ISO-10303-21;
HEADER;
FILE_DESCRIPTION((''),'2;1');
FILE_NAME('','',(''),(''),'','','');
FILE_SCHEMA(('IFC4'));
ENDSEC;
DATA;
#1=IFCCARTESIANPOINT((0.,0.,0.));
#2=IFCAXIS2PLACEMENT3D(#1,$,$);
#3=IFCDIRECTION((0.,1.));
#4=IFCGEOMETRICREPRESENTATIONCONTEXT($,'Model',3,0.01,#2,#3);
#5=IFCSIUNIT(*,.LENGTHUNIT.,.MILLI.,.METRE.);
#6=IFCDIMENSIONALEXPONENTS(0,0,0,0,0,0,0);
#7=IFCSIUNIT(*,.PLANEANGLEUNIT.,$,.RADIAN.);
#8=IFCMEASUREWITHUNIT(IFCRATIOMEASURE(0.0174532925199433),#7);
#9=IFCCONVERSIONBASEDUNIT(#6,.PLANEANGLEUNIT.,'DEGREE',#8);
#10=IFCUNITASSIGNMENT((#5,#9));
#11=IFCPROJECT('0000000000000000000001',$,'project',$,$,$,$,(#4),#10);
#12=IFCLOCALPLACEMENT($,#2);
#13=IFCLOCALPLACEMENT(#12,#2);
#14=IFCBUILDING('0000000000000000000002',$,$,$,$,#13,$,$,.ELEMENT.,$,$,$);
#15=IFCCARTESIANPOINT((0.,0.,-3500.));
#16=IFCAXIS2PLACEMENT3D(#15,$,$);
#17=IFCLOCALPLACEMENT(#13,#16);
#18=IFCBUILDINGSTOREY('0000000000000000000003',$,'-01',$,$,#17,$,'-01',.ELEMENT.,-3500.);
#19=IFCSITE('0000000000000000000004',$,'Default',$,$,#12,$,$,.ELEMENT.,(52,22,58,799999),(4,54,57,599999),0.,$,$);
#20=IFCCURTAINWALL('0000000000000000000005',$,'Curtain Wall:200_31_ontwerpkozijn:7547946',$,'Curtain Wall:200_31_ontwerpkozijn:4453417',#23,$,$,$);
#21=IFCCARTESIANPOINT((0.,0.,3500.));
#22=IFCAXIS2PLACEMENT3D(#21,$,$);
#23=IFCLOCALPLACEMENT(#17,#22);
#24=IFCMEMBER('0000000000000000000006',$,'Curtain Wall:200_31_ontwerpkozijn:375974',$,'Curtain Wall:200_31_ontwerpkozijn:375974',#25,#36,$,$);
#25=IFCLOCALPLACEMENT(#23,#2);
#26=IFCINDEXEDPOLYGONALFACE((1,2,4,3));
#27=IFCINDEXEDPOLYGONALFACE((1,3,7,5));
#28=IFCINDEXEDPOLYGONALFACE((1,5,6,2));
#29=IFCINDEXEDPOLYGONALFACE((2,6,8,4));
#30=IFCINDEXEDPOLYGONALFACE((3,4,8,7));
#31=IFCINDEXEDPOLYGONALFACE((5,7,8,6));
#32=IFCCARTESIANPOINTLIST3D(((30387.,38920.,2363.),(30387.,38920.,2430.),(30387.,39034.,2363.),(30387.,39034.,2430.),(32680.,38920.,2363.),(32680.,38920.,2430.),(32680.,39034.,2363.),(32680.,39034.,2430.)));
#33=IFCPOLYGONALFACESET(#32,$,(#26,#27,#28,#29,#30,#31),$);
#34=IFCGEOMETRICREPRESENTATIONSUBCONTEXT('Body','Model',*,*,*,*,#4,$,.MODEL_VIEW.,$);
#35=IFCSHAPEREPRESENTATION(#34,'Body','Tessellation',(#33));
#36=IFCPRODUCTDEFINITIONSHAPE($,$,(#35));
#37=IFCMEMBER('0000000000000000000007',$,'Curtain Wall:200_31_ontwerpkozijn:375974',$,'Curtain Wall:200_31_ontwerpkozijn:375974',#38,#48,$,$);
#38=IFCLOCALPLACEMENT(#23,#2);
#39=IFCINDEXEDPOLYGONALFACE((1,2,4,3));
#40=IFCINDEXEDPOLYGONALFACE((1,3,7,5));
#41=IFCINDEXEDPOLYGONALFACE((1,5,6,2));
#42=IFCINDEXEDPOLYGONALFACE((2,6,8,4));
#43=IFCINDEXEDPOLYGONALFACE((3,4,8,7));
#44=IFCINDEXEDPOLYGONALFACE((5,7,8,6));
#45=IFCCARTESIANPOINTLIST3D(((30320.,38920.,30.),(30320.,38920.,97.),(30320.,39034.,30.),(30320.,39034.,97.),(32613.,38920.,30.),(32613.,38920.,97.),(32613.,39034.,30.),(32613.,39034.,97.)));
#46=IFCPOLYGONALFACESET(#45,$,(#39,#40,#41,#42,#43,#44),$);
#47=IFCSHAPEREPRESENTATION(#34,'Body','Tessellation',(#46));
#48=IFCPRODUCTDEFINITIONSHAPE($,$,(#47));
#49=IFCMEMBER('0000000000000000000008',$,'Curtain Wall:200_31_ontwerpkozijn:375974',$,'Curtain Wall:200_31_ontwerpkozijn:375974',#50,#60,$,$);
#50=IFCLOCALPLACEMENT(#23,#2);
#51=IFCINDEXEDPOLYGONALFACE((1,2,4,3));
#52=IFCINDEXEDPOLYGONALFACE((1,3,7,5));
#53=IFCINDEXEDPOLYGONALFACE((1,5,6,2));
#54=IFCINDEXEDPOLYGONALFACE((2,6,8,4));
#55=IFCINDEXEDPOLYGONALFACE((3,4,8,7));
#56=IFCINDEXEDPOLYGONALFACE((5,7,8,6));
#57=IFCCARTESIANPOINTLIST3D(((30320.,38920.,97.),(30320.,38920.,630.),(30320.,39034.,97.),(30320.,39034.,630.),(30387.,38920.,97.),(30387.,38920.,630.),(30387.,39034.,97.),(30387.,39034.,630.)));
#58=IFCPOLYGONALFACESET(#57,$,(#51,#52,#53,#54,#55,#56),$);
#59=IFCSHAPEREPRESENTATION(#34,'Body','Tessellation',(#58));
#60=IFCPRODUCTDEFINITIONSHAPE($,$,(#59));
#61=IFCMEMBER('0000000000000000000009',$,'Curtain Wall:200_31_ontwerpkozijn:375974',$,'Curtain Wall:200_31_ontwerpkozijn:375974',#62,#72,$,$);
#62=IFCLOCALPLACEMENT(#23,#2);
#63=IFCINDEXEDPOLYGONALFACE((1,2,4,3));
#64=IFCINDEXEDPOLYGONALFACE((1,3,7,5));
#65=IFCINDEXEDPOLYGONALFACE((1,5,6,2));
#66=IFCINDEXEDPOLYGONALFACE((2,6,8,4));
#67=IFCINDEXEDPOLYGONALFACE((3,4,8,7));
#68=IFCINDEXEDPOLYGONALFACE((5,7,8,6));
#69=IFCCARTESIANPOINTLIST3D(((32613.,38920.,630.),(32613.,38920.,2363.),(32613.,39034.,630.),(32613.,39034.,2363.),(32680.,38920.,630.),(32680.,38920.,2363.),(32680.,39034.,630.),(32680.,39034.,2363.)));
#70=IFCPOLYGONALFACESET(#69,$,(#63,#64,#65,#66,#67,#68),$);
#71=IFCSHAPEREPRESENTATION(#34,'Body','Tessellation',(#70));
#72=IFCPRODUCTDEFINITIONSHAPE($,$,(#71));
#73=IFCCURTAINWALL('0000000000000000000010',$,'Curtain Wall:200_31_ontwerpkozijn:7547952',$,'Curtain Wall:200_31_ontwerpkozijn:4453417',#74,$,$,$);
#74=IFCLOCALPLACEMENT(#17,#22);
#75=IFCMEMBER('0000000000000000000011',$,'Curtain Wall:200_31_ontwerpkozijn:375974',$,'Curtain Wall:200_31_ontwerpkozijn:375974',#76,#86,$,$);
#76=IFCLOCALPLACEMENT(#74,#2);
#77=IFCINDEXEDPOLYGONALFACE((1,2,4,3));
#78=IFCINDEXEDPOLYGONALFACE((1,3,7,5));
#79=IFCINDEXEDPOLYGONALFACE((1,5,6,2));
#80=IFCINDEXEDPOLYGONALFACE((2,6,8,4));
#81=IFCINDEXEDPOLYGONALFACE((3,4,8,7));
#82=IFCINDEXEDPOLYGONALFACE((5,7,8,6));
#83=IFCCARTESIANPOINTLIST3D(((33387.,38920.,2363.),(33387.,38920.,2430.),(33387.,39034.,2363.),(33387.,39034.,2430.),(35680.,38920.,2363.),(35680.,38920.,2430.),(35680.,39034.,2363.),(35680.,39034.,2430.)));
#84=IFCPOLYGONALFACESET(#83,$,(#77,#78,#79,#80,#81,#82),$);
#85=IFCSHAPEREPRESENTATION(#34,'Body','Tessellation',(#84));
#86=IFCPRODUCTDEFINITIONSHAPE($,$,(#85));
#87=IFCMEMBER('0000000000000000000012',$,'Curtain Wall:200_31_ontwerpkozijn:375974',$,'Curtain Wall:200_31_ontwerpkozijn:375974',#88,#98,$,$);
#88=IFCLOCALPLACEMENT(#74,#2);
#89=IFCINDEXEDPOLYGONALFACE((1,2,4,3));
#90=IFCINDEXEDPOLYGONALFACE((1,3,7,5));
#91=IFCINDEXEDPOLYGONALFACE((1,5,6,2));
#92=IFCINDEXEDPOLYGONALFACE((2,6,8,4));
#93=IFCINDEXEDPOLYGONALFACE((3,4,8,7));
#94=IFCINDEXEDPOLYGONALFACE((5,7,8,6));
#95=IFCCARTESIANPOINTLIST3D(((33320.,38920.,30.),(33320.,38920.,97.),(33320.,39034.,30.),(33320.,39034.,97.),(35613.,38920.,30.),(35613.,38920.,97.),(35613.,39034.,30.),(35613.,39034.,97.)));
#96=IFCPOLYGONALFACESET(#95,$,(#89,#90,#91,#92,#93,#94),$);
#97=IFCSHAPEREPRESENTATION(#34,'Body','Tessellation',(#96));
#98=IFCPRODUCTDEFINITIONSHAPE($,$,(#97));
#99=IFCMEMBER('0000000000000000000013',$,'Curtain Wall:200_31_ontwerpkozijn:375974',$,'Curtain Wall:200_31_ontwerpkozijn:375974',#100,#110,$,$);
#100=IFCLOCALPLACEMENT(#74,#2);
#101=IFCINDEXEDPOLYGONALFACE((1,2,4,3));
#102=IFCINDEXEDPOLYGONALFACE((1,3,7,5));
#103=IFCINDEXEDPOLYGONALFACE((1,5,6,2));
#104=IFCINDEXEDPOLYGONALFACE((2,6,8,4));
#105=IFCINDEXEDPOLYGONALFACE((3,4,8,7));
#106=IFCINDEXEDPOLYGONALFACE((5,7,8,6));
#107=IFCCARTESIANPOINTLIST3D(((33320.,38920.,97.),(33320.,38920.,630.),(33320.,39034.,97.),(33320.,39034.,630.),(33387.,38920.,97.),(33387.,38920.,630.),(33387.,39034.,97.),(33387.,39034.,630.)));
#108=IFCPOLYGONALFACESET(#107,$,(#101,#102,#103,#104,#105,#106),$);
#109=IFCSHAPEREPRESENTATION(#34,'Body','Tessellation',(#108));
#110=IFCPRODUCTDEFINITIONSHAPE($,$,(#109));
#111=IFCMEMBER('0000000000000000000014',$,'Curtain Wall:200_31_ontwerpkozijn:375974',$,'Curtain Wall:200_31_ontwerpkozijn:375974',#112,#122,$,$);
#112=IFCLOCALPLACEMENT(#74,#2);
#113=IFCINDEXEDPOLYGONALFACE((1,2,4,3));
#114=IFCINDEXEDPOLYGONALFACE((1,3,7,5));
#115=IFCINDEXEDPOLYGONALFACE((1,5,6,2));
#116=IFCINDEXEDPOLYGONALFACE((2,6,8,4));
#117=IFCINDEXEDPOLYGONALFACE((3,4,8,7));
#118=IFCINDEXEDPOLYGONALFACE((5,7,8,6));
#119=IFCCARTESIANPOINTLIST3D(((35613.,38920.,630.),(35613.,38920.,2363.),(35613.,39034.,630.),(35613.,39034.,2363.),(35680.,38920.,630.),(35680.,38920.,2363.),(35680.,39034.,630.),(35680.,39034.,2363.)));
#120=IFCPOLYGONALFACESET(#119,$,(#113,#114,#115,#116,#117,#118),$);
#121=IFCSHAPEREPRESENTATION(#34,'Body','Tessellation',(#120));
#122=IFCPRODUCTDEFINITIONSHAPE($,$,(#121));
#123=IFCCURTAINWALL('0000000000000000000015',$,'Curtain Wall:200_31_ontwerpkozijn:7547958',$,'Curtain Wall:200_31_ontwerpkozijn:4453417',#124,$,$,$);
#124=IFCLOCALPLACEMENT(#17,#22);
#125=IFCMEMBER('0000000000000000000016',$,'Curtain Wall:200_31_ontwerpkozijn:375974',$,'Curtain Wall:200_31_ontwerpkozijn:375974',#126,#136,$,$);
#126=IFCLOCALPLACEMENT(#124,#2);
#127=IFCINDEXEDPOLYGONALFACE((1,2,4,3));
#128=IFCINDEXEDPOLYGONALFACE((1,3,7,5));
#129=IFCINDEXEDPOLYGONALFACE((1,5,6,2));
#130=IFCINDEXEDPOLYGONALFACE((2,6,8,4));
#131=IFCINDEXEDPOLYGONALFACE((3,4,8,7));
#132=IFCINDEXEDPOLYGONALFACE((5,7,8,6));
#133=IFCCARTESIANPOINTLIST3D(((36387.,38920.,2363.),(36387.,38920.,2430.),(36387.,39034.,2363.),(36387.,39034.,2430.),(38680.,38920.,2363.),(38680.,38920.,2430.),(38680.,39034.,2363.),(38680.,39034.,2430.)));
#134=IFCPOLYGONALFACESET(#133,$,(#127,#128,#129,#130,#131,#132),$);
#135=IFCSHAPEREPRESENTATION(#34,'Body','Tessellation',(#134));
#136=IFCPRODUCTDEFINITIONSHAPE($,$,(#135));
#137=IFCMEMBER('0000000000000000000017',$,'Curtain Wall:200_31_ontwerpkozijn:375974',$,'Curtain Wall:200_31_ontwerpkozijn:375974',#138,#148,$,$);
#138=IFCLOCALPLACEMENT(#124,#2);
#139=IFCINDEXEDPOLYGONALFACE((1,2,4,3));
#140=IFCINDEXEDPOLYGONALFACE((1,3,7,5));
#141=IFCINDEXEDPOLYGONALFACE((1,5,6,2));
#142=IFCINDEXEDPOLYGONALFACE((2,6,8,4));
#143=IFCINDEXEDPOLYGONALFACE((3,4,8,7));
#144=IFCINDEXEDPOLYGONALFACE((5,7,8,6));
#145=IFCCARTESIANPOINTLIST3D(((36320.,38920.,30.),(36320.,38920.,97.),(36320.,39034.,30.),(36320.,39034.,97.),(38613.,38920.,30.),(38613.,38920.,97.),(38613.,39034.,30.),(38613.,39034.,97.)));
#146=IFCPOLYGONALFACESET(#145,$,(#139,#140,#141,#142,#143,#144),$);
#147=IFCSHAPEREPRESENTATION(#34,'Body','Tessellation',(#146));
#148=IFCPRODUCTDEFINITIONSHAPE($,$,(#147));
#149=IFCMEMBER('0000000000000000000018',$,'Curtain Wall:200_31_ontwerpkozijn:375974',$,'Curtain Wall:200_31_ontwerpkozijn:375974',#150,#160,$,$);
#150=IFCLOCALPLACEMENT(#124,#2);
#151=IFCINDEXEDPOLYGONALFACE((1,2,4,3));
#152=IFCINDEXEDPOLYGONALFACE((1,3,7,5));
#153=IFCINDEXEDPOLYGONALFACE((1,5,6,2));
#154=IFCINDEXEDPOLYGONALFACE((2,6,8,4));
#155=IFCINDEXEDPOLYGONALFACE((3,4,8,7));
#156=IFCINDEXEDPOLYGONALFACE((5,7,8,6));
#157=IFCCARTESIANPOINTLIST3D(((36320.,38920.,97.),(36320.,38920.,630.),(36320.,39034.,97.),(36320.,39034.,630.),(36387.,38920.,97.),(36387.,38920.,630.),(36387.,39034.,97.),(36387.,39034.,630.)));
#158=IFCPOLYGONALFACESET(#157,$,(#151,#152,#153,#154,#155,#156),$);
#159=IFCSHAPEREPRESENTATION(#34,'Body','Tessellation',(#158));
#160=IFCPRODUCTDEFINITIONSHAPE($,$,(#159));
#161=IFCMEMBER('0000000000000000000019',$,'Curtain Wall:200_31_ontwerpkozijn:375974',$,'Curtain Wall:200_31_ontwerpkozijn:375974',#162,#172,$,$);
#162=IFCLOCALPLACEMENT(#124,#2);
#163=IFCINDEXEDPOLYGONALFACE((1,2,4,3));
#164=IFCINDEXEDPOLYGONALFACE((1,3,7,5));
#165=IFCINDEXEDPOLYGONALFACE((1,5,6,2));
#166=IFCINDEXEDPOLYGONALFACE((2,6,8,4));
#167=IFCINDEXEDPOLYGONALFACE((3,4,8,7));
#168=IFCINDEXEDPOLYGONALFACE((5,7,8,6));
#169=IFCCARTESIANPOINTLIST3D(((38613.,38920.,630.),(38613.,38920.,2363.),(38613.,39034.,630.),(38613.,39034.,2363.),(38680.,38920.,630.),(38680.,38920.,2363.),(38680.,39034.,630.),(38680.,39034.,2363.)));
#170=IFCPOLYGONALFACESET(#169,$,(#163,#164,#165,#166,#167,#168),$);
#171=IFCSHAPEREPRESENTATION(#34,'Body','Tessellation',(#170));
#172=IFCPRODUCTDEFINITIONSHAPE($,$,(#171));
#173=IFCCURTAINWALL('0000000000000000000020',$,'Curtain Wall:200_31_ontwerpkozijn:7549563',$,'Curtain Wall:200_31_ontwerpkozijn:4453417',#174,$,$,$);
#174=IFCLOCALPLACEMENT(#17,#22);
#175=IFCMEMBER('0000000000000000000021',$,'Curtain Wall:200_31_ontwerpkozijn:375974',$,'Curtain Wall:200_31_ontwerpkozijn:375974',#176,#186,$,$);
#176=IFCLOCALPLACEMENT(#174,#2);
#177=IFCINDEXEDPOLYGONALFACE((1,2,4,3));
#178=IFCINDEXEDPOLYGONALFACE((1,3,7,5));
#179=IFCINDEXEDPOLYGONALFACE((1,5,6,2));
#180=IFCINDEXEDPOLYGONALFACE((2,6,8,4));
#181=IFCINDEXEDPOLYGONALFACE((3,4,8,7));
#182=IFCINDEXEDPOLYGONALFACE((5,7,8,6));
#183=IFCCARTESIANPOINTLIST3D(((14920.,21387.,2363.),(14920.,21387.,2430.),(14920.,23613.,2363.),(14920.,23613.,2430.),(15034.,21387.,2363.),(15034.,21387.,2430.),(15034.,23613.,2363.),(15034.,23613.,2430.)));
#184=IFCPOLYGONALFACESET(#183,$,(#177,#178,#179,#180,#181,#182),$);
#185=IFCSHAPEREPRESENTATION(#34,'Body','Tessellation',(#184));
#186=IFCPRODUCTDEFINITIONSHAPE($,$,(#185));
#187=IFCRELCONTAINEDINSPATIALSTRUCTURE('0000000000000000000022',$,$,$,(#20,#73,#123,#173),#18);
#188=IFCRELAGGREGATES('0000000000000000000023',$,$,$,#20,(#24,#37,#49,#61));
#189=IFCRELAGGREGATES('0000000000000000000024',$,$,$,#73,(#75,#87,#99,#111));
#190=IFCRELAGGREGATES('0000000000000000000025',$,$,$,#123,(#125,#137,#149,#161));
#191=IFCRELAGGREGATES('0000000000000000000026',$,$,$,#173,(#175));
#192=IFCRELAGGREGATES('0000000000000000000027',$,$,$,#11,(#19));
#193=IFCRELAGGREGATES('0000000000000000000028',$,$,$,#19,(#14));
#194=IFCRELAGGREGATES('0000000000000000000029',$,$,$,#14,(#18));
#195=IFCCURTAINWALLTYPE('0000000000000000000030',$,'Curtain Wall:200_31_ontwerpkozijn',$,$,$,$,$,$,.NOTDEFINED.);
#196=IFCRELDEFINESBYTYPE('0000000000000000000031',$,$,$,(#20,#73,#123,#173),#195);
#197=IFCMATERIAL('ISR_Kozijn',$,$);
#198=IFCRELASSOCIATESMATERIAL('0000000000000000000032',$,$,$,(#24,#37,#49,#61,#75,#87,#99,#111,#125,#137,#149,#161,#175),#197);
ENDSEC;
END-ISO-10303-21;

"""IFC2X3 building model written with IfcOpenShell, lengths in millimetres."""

from ifc_helpers import new_model, entity, si_unit, converted_unit, direction, frame, frame_2d, origin, origin_2d_with_axis, place, context, subcontext, project, spatial, rectangle, extrude, material, type_object, element, aggregate, save


model = new_model("IFC2X3")

# Units and contexts
model_context = context("Model", 3, precision=0.01, world=origin(), true_north=direction((0.0, 1.0)))
body_context = subcontext(model_context, "Body", "Model", "MODEL_VIEW")
ifc_project = project(units=[si_unit("LENGTHUNIT", "METRE", prefix="MILLI"), converted_unit("PLANEANGLEUNIT", "DEGREE", entity("IfcRatioMeasure", 0.0174532925199433), si_unit("PLANEANGLEUNIT", "RADIAN"), dimensions=[0, 0, 0, 0, 0, 0, 0])], contexts=[model_context])

# Site, building, storey
site_placement = place(None, origin())
site = spatial("IfcSite", under=ifc_project, at=site_placement, Name="Default", CompositionType="ELEMENT", RefLatitude=(52, 22, 58, 799999), RefLongitude=(4, 54, 57, 599999), RefElevation=0.0)
building_placement = place(site_placement, origin())
building = spatial("IfcBuilding", under=site, at=building_placement, CompositionType="ELEMENT")
storey_placement = place(building_placement, frame((0.0, 0.0, -3500.0)))
storey = spatial("IfcBuildingStorey", under=building, at=storey_placement, Name="-01", LongName="-01", CompositionType="ELEMENT", Elevation=-3500.0)

# Curtain walls, members
curtain_wall_type = type_object("IfcCurtainWallType", Name="Curtain Wall:200_31_ontwerpkozijn", PredefinedType="NOTDEFINED")
ifc_material = material(Name="ISR_Kozijn")
curtain_wall_1_placement = place(storey_placement, frame((0.0, 0.0, 3500.0)))
curtain_wall_1 = element("IfcCurtainWall", 1, at=curtain_wall_1_placement, inside=storey, type_object=curtain_wall_type, Name="Curtain Wall:200_31_ontwerpkozijn:7547946", ObjectType="Curtain Wall:200_31_ontwerpkozijn:4453417")
member_1_placement = place(curtain_wall_1_placement, origin())
member_1 = element("IfcMember", 2, at=member_1_placement, material=ifc_material, Name="Curtain Wall:200_31_ontwerpkozijn:375974", ObjectType="Curtain Wall:200_31_ontwerpkozijn:375974", context=body_context, shape_type="SweptSolid", body=[
    extrude(rectangle(XDim=67.0, YDim=114.0, at=frame_2d((0.0, 0.0), x_axis=(1.0, 0.0))), frame((30387.0, 38977.0, 2396.5), z_axis=(1.0, 0.0, 0.0), x_axis=(0.0, 0.0, -1.0)), (0.0, 0.0, 1.0), 2293.0),
])
member_2_placement = place(curtain_wall_1_placement, origin())
member_2 = element("IfcMember", 3, at=member_2_placement, material=ifc_material, Name="Curtain Wall:200_31_ontwerpkozijn:375974", ObjectType="Curtain Wall:200_31_ontwerpkozijn:375974", context=body_context, shape_type="SweptSolid", body=[
    extrude(rectangle(XDim=67.0, YDim=114.0, at=frame_2d((0.0, 0.0), x_axis=(1.0, 0.0))), frame((32613.0, 38977.0, 63.5), z_axis=(-1.0, 0.0, 0.0), x_axis=(0.0, 0.0, -1.0)), (0.0, 0.0, 1.0), 2293.0),
])
member_3_placement = place(curtain_wall_1_placement, origin())
member_3 = element("IfcMember", 4, at=member_3_placement, material=ifc_material, Name="Curtain Wall:200_31_ontwerpkozijn:375974", ObjectType="Curtain Wall:200_31_ontwerpkozijn:375974", context=body_context, shape_type="SweptSolid", body=[
    extrude(rectangle(XDim=67.0, YDim=114.0, at=frame_2d((0.0, 0.0), x_axis=(1.0, 0.0))), frame((30353.5, 38977.0, 97.0), z_axis=(0.0, 0.0, 1.0), x_axis=(-1.0, 0.0, 0.0)), (0.0, 0.0, 1.0), 533.0),
])
member_4_placement = place(curtain_wall_1_placement, origin())
member_4 = element("IfcMember", 5, at=member_4_placement, material=ifc_material, Name="Curtain Wall:200_31_ontwerpkozijn:375974", ObjectType="Curtain Wall:200_31_ontwerpkozijn:375974", context=body_context, shape_type="SweptSolid", body=[
    extrude(rectangle(XDim=67.0, YDim=114.0, at=frame_2d((0.0, 0.0), x_axis=(1.0, 0.0))), frame((32646.5, 38977.0, 2363.0), z_axis=(0.0, 0.0, -1.0), x_axis=(-1.0, 0.0, 0.0)), (0.0, 0.0, 1.0), 1733.0),
])
aggregate(curtain_wall_1, [member_1, member_2, member_3, member_4])
curtain_wall_2_placement = place(storey_placement, frame((0.0, 0.0, 3500.0)))
curtain_wall_2 = element("IfcCurtainWall", 6, at=curtain_wall_2_placement, inside=storey, type_object=curtain_wall_type, Name="Curtain Wall:200_31_ontwerpkozijn:7547952", ObjectType="Curtain Wall:200_31_ontwerpkozijn:4453417")
member_5_placement = place(curtain_wall_2_placement, origin())
member_5 = element("IfcMember", 7, at=member_5_placement, material=ifc_material, Name="Curtain Wall:200_31_ontwerpkozijn:375974", ObjectType="Curtain Wall:200_31_ontwerpkozijn:375974", context=body_context, shape_type="SweptSolid", body=[
    extrude(rectangle(XDim=67.0, YDim=114.0, at=frame_2d((0.0, 0.0), x_axis=(1.0, 0.0))), frame((33387.0, 38977.0, 2396.5), z_axis=(1.0, 0.0, 0.0), x_axis=(0.0, 0.0, -1.0)), (0.0, 0.0, 1.0), 2293.0),
])
member_6_placement = place(curtain_wall_2_placement, origin())
member_6 = element("IfcMember", 8, at=member_6_placement, material=ifc_material, Name="Curtain Wall:200_31_ontwerpkozijn:375974", ObjectType="Curtain Wall:200_31_ontwerpkozijn:375974", context=body_context, shape_type="SweptSolid", body=[
    extrude(rectangle(XDim=67.0, YDim=114.0, at=frame_2d((0.0, 0.0), x_axis=(1.0, 0.0))), frame((35613.0, 38977.0, 63.5), z_axis=(-1.0, 0.0, 0.0), x_axis=(0.0, 0.0, -1.0)), (0.0, 0.0, 1.0), 2293.0),
])
member_7_placement = place(curtain_wall_2_placement, origin())
member_7 = element("IfcMember", 9, at=member_7_placement, material=ifc_material, Name="Curtain Wall:200_31_ontwerpkozijn:375974", ObjectType="Curtain Wall:200_31_ontwerpkozijn:375974", context=body_context, shape_type="SweptSolid", body=[
    extrude(rectangle(XDim=67.0, YDim=114.0, at=frame_2d((0.0, 0.0), x_axis=(1.0, 0.0))), frame((33353.5, 38977.0, 97.0), z_axis=(0.0, 0.0, 1.0), x_axis=(-1.0, 0.0, 0.0)), (0.0, 0.0, 1.0), 533.0),
])
member_8_placement = place(curtain_wall_2_placement, origin())
member_8 = element("IfcMember", 10, at=member_8_placement, material=ifc_material, Name="Curtain Wall:200_31_ontwerpkozijn:375974", ObjectType="Curtain Wall:200_31_ontwerpkozijn:375974", context=body_context, shape_type="SweptSolid", body=[
    extrude(rectangle(XDim=67.0, YDim=114.0, at=frame_2d((0.0, 0.0), x_axis=(1.0, 0.0))), frame((35646.5, 38977.0, 2363.0), z_axis=(0.0, 0.0, -1.0), x_axis=(-1.0, 0.0, 0.0)), (0.0, 0.0, 1.0), 1733.0),
])
aggregate(curtain_wall_2, [member_5, member_6, member_7, member_8])
curtain_wall_3_placement = place(storey_placement, frame((0.0, 0.0, 3500.0)))
curtain_wall_3 = element("IfcCurtainWall", 11, at=curtain_wall_3_placement, inside=storey, type_object=curtain_wall_type, Name="Curtain Wall:200_31_ontwerpkozijn:7547958", ObjectType="Curtain Wall:200_31_ontwerpkozijn:4453417")
member_9_placement = place(curtain_wall_3_placement, origin())
member_9 = element("IfcMember", 12, at=member_9_placement, material=ifc_material, Name="Curtain Wall:200_31_ontwerpkozijn:375974", ObjectType="Curtain Wall:200_31_ontwerpkozijn:375974", context=body_context, shape_type="SweptSolid", body=[
    extrude(rectangle(XDim=67.0, YDim=114.0, at=frame_2d((0.0, 0.0), x_axis=(1.0, 0.0))), frame((36387.0, 38977.0, 2396.5), z_axis=(1.0, 0.0, 0.0), x_axis=(0.0, 0.0, -1.0)), (0.0, 0.0, 1.0), 2293.0),
])
member_10_placement = place(curtain_wall_3_placement, origin())
member_10 = element("IfcMember", 13, at=member_10_placement, material=ifc_material, Name="Curtain Wall:200_31_ontwerpkozijn:375974", ObjectType="Curtain Wall:200_31_ontwerpkozijn:375974", context=body_context, shape_type="SweptSolid", body=[
    extrude(rectangle(XDim=67.0, YDim=114.0, at=frame_2d((0.0, 0.0), x_axis=(1.0, 0.0))), frame((38613.0, 38977.0, 63.5), z_axis=(-1.0, 0.0, 0.0), x_axis=(0.0, 0.0, -1.0)), (0.0, 0.0, 1.0), 2293.0),
])
member_11_placement = place(curtain_wall_3_placement, origin())
member_11 = element("IfcMember", 14, at=member_11_placement, material=ifc_material, Name="Curtain Wall:200_31_ontwerpkozijn:375974", ObjectType="Curtain Wall:200_31_ontwerpkozijn:375974", context=body_context, shape_type="SweptSolid", body=[
    extrude(rectangle(XDim=67.0, YDim=114.0, at=frame_2d((0.0, 0.0), x_axis=(1.0, 0.0))), frame((36353.5, 38977.0, 97.0), z_axis=(0.0, 0.0, 1.0), x_axis=(-1.0, 0.0, 0.0)), (0.0, 0.0, 1.0), 533.0),
])
member_12_placement = place(curtain_wall_3_placement, origin())
member_12 = element("IfcMember", 15, at=member_12_placement, material=ifc_material, Name="Curtain Wall:200_31_ontwerpkozijn:375974", ObjectType="Curtain Wall:200_31_ontwerpkozijn:375974", context=body_context, shape_type="SweptSolid", body=[
    extrude(rectangle(XDim=67.0, YDim=114.0, at=frame_2d((0.0, 0.0), x_axis=(1.0, 0.0))), frame((38646.5, 38977.0, 2363.0), z_axis=(0.0, 0.0, -1.0), x_axis=(-1.0, 0.0, 0.0)), (0.0, 0.0, 1.0), 1733.0),
])
aggregate(curtain_wall_3, [member_9, member_10, member_11, member_12])
curtain_wall_4_placement = place(storey_placement, frame((0.0, 0.0, 3500.0)))
curtain_wall_4 = element("IfcCurtainWall", 16, at=curtain_wall_4_placement, inside=storey, type_object=curtain_wall_type, Name="Curtain Wall:200_31_ontwerpkozijn:7549563", ObjectType="Curtain Wall:200_31_ontwerpkozijn:4453417")
member_13_placement = place(curtain_wall_4_placement, origin())
member_13 = element("IfcMember", 17, at=member_13_placement, material=ifc_material, Name="Curtain Wall:200_31_ontwerpkozijn:375974", ObjectType="Curtain Wall:200_31_ontwerpkozijn:375974", context=body_context, shape_type="SweptSolid", body=[
    extrude(rectangle(XDim=67.0, YDim=114.0, at=origin_2d_with_axis()), frame((14977.0, 21387.0, 2396.5), z_axis=(0.0, 1.0, 0.0), x_axis=(0.0, 0.0, -1.0)), (0.0, 0.0, 1.0), 2226.0),
])
aggregate(curtain_wall_4, [member_13])

save(model, "model.ifc")
